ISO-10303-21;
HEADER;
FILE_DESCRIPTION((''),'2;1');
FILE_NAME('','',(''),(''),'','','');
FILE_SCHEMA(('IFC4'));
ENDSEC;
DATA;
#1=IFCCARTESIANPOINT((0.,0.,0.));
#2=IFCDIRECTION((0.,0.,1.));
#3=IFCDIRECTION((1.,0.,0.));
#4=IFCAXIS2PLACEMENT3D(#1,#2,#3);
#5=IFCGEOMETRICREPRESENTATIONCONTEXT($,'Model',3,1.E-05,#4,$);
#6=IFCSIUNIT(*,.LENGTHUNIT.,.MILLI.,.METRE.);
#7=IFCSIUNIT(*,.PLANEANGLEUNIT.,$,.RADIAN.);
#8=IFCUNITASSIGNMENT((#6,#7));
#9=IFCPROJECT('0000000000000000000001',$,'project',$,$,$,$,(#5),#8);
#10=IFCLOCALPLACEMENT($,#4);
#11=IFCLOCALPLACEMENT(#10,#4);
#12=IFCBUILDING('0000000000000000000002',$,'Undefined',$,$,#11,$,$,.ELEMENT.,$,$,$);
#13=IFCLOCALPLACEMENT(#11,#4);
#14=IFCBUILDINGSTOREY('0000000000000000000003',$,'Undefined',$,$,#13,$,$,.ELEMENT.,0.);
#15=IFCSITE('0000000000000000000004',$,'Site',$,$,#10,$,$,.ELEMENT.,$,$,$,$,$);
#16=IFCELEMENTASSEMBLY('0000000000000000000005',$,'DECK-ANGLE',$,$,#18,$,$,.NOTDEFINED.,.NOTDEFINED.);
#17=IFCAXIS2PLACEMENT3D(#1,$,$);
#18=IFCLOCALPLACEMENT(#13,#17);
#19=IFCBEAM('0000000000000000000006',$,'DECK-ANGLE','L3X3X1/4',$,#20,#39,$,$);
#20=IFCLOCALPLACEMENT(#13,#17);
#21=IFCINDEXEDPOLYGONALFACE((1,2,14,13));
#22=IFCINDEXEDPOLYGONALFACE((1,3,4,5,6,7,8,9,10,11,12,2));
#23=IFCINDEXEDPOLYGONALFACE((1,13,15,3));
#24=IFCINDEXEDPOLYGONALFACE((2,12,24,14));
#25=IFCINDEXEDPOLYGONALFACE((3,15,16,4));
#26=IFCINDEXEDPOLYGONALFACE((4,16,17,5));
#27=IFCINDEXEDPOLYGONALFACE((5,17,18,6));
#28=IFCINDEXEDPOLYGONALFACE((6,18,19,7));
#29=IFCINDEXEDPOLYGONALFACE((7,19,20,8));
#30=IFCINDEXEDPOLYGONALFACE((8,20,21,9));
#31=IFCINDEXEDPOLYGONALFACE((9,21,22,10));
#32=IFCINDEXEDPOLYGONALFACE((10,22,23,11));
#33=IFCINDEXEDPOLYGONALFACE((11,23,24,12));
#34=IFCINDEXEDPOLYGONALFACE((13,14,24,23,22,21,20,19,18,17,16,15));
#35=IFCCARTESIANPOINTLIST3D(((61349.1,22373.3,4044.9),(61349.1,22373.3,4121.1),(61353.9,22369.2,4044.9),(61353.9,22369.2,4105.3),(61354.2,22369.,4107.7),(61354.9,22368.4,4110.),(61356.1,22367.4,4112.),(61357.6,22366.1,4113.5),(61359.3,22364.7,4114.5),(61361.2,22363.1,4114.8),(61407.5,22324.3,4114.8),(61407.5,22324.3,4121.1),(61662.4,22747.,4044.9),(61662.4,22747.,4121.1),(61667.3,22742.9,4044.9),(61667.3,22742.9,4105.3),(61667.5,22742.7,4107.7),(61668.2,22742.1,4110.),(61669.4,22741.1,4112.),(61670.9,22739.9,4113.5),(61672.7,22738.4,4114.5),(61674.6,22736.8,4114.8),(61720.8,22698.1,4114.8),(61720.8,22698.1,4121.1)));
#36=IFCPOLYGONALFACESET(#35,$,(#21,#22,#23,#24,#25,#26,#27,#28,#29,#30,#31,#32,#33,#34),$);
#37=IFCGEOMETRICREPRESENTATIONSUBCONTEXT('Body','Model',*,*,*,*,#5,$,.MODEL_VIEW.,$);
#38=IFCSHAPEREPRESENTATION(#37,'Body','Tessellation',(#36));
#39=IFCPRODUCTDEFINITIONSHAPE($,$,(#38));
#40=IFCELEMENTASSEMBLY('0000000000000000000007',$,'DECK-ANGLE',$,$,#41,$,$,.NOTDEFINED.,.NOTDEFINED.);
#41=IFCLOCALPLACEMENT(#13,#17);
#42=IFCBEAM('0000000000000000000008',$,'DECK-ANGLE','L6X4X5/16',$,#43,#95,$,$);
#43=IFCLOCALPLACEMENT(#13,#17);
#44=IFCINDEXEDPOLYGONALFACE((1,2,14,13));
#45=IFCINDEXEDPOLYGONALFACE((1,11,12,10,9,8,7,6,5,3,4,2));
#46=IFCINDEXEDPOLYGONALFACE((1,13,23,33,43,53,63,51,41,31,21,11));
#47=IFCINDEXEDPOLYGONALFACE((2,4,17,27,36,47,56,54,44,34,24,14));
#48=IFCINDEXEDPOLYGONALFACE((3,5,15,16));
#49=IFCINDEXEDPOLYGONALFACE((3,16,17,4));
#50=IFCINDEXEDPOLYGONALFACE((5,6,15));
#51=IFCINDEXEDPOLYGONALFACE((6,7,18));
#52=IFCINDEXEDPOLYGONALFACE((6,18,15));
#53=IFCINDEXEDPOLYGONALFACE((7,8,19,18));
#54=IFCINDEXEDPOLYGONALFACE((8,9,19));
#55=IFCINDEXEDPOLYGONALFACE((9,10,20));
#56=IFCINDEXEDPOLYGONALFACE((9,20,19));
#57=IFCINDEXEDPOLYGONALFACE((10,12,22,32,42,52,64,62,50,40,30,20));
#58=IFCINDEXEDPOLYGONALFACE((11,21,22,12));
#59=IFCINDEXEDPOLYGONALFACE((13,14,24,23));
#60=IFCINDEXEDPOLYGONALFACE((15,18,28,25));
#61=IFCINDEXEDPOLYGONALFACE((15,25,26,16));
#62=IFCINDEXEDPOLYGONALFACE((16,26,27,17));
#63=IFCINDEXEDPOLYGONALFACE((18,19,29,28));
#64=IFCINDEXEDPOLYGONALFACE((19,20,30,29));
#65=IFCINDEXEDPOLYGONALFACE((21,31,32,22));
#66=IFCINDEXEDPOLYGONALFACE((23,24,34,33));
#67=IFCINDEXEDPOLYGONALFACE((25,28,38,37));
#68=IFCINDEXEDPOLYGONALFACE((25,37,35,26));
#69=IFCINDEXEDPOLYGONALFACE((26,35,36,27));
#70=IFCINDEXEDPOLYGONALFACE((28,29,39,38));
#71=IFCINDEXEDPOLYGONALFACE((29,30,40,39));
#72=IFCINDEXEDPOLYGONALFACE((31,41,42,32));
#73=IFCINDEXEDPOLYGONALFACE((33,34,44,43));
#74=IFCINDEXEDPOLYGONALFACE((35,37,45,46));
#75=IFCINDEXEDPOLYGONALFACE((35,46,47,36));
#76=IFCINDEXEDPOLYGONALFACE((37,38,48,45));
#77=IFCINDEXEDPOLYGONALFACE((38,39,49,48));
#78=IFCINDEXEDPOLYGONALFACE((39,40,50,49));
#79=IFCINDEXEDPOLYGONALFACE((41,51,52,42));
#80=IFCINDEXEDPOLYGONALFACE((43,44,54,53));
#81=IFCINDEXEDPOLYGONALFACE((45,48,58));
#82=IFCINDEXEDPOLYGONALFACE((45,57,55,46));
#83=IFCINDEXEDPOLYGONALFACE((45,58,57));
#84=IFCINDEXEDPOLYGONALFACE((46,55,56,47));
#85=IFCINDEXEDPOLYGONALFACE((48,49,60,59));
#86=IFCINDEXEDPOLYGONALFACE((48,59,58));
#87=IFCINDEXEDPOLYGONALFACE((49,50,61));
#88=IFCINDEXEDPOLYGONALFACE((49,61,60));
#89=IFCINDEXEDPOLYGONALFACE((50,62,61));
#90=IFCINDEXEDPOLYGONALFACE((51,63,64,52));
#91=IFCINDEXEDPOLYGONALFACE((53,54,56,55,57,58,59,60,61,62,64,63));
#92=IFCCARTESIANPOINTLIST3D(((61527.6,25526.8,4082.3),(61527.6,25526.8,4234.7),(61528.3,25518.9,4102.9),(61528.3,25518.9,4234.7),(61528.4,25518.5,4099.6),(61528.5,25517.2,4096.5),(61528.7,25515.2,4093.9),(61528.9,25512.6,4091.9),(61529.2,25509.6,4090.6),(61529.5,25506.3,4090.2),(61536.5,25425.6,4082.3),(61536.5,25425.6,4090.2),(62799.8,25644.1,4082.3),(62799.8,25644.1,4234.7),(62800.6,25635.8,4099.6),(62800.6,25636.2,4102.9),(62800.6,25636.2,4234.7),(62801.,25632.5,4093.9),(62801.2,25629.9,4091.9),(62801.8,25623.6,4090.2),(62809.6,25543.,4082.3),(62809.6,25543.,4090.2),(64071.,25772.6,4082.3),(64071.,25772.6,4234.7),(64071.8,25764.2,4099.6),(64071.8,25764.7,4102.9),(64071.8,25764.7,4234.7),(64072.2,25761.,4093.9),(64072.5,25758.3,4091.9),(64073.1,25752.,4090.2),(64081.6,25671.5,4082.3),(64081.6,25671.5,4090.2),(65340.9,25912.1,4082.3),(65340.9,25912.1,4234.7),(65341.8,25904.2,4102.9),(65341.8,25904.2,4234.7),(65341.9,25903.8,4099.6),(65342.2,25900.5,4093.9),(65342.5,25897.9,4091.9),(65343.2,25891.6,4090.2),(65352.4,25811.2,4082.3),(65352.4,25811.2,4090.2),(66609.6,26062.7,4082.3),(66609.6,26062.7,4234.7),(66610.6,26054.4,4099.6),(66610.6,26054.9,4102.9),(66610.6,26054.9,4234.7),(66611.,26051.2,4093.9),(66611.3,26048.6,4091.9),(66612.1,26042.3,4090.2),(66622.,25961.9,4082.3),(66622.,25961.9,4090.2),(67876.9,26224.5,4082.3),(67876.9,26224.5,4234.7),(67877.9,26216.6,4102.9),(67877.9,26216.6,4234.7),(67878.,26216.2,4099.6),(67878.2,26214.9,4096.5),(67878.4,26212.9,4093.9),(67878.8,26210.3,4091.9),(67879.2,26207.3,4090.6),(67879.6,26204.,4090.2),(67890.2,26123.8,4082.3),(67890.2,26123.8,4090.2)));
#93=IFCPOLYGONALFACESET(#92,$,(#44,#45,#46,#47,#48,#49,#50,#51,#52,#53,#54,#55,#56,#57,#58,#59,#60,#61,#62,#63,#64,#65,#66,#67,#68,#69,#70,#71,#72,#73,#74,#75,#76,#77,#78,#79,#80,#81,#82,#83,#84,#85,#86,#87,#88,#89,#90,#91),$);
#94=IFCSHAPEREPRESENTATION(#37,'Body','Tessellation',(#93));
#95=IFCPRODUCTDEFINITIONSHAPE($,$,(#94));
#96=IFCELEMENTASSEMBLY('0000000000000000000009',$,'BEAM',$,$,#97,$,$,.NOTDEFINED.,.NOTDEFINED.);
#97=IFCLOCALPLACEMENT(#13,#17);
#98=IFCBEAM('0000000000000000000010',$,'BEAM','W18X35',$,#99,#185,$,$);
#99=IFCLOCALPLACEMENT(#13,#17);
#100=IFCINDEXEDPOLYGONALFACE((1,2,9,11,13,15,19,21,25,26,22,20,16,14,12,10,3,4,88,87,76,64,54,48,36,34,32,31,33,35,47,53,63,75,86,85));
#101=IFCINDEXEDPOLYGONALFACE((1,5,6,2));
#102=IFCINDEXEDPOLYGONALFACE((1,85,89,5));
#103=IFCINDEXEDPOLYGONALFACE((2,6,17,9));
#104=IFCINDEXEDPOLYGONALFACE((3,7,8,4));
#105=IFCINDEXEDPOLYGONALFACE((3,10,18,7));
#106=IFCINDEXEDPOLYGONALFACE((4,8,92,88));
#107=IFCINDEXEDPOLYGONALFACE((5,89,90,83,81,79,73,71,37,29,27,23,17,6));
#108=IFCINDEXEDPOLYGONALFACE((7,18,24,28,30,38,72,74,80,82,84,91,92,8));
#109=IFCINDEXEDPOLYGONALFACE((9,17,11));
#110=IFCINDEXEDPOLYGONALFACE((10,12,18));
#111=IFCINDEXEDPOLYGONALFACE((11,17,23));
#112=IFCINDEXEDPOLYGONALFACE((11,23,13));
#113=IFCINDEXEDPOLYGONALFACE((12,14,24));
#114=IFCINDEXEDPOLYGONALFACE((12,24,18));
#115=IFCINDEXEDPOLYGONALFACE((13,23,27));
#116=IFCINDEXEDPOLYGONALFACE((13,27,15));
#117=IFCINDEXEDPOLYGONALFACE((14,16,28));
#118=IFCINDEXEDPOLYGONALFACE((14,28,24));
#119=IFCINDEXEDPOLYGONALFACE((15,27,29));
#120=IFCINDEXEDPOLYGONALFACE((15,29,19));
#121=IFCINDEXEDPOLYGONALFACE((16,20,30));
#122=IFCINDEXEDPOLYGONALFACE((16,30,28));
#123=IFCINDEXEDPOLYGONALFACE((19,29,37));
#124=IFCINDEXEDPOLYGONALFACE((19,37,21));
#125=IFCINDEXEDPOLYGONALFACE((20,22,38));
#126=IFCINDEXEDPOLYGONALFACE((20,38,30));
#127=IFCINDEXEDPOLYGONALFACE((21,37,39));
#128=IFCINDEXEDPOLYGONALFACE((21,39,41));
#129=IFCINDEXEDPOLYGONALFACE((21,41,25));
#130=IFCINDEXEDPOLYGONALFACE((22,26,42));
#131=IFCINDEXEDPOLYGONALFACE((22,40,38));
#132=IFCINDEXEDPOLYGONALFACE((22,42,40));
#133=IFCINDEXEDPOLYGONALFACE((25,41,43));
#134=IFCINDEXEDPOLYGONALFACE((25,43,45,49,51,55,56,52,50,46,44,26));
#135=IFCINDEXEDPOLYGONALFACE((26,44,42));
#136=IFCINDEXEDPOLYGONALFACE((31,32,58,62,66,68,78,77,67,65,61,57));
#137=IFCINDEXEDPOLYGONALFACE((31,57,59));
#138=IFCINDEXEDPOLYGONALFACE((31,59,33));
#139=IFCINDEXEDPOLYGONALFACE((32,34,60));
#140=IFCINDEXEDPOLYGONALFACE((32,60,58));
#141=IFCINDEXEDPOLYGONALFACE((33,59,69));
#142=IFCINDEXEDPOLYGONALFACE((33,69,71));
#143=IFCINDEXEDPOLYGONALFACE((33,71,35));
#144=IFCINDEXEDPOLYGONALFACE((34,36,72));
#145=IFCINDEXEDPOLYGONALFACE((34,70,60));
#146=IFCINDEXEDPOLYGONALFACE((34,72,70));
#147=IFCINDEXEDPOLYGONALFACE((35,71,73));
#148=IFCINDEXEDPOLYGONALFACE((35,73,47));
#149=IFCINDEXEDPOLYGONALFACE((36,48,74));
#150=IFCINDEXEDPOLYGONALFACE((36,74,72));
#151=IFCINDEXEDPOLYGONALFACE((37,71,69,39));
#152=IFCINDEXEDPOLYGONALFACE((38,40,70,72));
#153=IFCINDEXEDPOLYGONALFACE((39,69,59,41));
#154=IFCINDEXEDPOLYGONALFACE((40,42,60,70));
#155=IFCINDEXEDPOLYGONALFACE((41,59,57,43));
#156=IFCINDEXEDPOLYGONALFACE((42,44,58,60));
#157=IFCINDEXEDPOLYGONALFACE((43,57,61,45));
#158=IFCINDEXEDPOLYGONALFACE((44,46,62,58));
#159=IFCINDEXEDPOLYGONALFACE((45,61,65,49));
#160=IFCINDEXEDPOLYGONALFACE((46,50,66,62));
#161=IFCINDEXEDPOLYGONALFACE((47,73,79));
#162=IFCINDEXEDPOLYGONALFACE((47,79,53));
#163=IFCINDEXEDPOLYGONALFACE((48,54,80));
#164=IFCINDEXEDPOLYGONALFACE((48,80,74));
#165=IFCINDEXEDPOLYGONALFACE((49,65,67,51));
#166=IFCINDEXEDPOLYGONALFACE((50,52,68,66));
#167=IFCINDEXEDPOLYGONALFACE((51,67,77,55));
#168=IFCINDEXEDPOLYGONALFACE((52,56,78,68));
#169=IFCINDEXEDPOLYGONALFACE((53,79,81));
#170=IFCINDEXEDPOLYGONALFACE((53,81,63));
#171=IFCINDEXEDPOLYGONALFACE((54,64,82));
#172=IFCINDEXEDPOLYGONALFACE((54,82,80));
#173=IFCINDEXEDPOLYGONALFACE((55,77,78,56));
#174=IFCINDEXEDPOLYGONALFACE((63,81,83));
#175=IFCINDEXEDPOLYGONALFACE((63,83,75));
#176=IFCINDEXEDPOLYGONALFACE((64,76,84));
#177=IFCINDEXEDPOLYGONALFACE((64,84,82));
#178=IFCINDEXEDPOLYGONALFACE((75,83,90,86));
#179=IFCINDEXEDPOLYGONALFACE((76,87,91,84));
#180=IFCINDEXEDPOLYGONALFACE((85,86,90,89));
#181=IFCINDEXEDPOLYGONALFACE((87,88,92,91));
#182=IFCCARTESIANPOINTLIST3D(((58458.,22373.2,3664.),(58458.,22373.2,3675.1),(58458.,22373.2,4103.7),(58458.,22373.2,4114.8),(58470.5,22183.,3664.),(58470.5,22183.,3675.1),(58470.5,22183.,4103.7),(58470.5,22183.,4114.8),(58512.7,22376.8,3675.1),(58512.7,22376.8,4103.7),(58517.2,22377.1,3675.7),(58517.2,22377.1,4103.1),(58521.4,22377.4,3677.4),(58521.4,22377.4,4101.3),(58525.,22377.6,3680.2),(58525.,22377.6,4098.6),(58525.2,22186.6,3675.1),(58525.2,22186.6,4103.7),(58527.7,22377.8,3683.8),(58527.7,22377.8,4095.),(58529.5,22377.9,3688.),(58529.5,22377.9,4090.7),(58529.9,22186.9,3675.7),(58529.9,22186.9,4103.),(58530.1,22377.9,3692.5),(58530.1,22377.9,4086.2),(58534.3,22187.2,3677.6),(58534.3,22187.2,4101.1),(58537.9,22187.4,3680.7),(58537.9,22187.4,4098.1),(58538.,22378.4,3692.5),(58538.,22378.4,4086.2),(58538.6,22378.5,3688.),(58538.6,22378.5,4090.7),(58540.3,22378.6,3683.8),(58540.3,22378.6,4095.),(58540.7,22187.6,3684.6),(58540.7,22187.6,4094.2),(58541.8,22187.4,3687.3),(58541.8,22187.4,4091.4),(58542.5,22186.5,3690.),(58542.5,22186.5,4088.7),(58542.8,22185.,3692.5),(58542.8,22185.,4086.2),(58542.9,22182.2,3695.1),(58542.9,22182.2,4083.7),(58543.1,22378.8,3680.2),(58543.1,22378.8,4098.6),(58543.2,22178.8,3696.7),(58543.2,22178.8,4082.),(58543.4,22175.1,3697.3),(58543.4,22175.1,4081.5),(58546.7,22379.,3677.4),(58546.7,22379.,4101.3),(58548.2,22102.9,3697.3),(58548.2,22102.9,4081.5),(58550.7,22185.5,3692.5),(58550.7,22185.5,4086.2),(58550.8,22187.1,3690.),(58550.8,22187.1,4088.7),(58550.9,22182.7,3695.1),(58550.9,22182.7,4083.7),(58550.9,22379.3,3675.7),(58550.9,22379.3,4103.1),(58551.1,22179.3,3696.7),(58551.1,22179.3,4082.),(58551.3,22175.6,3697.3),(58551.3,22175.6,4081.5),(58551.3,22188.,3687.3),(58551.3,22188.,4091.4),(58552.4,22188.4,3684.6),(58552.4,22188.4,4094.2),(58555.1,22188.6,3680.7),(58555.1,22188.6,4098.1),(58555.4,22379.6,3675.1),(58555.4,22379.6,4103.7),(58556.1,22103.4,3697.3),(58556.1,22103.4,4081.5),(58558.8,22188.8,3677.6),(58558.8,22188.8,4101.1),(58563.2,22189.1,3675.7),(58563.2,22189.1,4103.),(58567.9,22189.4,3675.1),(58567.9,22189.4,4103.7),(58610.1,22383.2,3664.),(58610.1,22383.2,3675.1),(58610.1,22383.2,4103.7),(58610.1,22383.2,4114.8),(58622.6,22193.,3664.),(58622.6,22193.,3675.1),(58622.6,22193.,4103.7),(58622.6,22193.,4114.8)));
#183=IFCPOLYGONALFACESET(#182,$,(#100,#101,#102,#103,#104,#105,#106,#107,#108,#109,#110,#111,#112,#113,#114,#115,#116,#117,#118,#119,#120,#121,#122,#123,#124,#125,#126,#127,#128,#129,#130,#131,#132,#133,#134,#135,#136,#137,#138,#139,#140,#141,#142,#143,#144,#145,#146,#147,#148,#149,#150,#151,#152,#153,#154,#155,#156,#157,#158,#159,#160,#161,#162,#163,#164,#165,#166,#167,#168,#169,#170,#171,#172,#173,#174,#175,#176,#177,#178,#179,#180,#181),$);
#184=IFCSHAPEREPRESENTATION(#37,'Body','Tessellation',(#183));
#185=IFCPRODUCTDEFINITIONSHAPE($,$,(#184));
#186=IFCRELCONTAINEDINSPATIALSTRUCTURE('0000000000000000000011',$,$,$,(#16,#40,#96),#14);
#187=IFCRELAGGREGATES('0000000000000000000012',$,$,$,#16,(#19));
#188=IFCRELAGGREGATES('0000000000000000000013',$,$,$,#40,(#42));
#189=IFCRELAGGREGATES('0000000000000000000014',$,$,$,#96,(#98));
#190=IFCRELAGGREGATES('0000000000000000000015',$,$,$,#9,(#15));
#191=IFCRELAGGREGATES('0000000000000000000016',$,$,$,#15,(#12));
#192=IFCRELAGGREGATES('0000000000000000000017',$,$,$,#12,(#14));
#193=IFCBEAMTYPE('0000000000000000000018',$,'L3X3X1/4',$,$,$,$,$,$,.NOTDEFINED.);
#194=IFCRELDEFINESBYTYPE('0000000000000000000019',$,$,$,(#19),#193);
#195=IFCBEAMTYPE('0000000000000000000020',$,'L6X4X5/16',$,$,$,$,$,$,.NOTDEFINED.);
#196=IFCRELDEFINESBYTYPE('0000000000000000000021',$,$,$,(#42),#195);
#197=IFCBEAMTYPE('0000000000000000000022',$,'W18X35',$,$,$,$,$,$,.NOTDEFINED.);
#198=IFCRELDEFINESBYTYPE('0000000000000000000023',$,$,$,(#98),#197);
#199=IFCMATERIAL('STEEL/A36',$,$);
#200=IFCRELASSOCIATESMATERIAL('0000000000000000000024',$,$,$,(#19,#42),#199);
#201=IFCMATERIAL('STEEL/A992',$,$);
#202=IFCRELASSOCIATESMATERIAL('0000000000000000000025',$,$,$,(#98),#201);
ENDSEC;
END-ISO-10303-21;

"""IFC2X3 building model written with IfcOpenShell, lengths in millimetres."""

from ifc_helpers import new_model, entity, si_unit, frame, frame_2d, origin_with_axes, origin_2d_with_axis, place, context, subcontext, project, spatial, polyline, circle_curve, parameter, trimmed, segment, composite_curve, i_section, l_section, outline, extrude, boolean, halfspace, material, type_object, element, aggregate, save


model = new_model("IFC2X3")

# Units and contexts
model_context = context("Model", 3, precision=1e-05, world=origin_with_axes())
body_context = subcontext(model_context, "Body", "Model", "MODEL_VIEW")
ifc_project = project(units=[si_unit("LENGTHUNIT", "METRE", prefix="MILLI"), si_unit("PLANEANGLEUNIT", "RADIAN")], contexts=[model_context])

# Site, building, storey
site_placement = place(None, origin_with_axes())
site = spatial("IfcSite", under=ifc_project, at=site_placement, Name="Site", CompositionType="ELEMENT")
building_placement = place(site_placement, origin_with_axes())
building = spatial("IfcBuilding", under=site, at=building_placement, Name="Undefined", CompositionType="ELEMENT")
storey_placement = place(building_placement, origin_with_axes())
storey = spatial("IfcBuildingStorey", under=building, at=storey_placement, Name="Undefined", CompositionType="ELEMENT", Elevation=0.0)

# Element assemblies, beams
ifc_material_1 = material(Name="STEEL/A36")
beam_type_1 = type_object("IfcBeamType", Name="L3X3X1/4", PredefinedType="NOTDEFINED")
assembly_1_placement = place(storey_placement, origin_with_axes())
assembly_1 = element("IfcElementAssembly", 1, at=assembly_1_placement, inside=storey, Name="DECK-ANGLE", AssemblyPlace="NOTDEFINED", PredefinedType="NOTDEFINED")
beam_1_placement = place(assembly_1_placement, frame((61691.6, 22722.5, 4083.0), z_axis=(0.0, 0.0, -1.0), x_axis=(-0.642441, -0.766335, 0.0)))
beam_1 = element("IfcBeam", 2, at=beam_1_placement, type_object=beam_type_1, material=ifc_material_1, Name="DECK-ANGLE", Description="L3X3X1/4", context=body_context, shape_type="SweptSolid", body=[
    extrude(l_section(Depth=76.2, Width=76.2, Thickness=6.3, FilletRadius=9.5, at=origin_2d_with_axis()), frame((487.7, 0.0, 0.0), z_axis=(-1.0, 0.0, 0.0), x_axis=(0.0, -1.0, 0.0)), (0.0, 0.0, 1.0), 487.7),
])
aggregate(assembly_1, [beam_1])
assembly_2_placement = place(storey_placement, origin_with_axes())
assembly_2 = element("IfcElementAssembly", 3, at=assembly_2_placement, inside=storey, Name="DECK-ANGLE", AssemblyPlace="NOTDEFINED", PredefinedType="NOTDEFINED")
beam_type_2 = type_object("IfcBeamType", Name="L6X4X5/16", PredefinedType="NOTDEFINED")
beam_2_placement = place(assembly_2_placement, frame((61532.1, 25476.2, 4158.5), z_axis=(0.0, 0.0, 1.0), x_axis=(0.994018, 0.109219, 0.0)))
beam_2 = element("IfcBeam", 4, at=beam_2_placement, type_object=beam_type_2, material=ifc_material_1, Name="DECK-ANGLE", Description="L6X4X5/16", context=body_context, shape_type="SweptSolid", body=[
    entity("IfcRevolvedAreaSolid", entity("IfcLShapeProfileDef", "AREA", None, entity("IfcAxis2Placement2D", entity("IfcCartesianPoint", [0.0, 0.0]), entity("IfcDirection", [1.0, 0.0])), 152.4, 101.6, 7.9, 12.7), entity("IfcAxis2Placement3D", entity("IfcCartesianPoint", [6389.7, 0.0, 0.0]), entity("IfcDirection", [-0.999761, -0.021875, 0.0]), entity("IfcDirection", [0.021875, -0.999761, 0.0])), entity("IfcAxis1Placement", entity("IfcCartesianPoint", [-146050.0, 0.0, 0.0]), entity("IfcDirection", [0.0, -1.0, 0.0])), 0.043753),
])
aggregate(assembly_2, [beam_2])
assembly_3_placement = place(storey_placement, origin_with_axes())
assembly_3 = element("IfcElementAssembly", 5, at=assembly_3_placement, inside=storey, Name="BEAM", AssemblyPlace="NOTDEFINED", PredefinedType="NOTDEFINED")
ifc_material_2 = material(Name="STEEL/A992")
beam_type_3 = type_object("IfcBeamType", Name="W18X35", PredefinedType="NOTDEFINED")
beam_3_placement = place(assembly_3_placement, frame((58552.4, 22099.4, 3889.4), z_axis=(0.0, 0.0, 1.0), x_axis=(-0.065571, 0.997848, 0.0)))
beam_3 = element("IfcBeam", 6, at=beam_3_placement, type_object=beam_type_3, material=ifc_material_2, Name="BEAM", Description="W18X35", context=body_context, shape_type="CSG", body=[
    boolean("DIFFERENCE", boolean("DIFFERENCE", boolean("DIFFERENCE", boolean("DIFFERENCE", extrude(i_section(OverallWidth=152.4, OverallDepth=450.9, WebThickness=7.9, FlangeThickness=11.1, FilletRadius=17.5, at=origin_2d_with_axis()), frame((298.4, 0.0, 0.0), z_axis=(-1.0, 0.0, 0.0), x_axis=(0.0, -1.0, 0.0)), (0.0, 0.0, 1.0), 309.7), extrude(outline(composite_curve([segment(polyline([(0.0, 0.0), (82.3, 0.0)]), True, "CONTINUOUS"), segment(trimmed(circle_curve(frame_2d((82.3, 12.7), x_axis=(0.0, -1.0)), 12.7), [parameter(0.0)], [parameter(1.570796)], True, "PARAMETER"), True, "CONTINUOUS"), segment(polyline([(95.0, 12.7), (95.0, 43.3), (0.0, 43.3), (0.0, 0.0)]), True, "CONTINUOUS")], self_intersect=True)), frame((-6.2, -86.2, -192.1), z_axis=(-0.000015, 1.0, 0.0), x_axis=(1.0, 0.000015, 0.0)), (0.0, 0.0, 1.0), 172.4)), extrude(outline(composite_curve([segment(polyline([(0.0, 0.0), (82.3, 0.0)]), True, "CONTINUOUS"), segment(trimmed(circle_curve(frame_2d((82.3, 12.7), x_axis=(0.0, -1.0)), 12.7), [parameter(0.0)], [parameter(1.570796)], True, "PARAMETER"), True, "CONTINUOUS"), segment(polyline([(95.0, 12.7), (95.0, 43.3), (0.0, 43.3), (0.0, 0.0)]), True, "CONTINUOUS")], self_intersect=True)), frame((-6.2, 86.2, 192.1), z_axis=(0.000015, -1.0, 0.0), x_axis=(1.0, 0.000015, 0.0)), (0.0, 0.0, 1.0), 172.4)), halfspace(frame((279.4, 101.6, -1025.4), z_axis=(-1.0, 0.0, 0.0), x_axis=(0.0, 0.0, 1.0)), True)), halfspace(frame((3.8, 0.0, 325.4), z_axis=(-1.0, -0.00004, 0.0), x_axis=(0.00004, -1.0, 0.0)), False)),
])

aggregate(assembly_3, [beam_3])

save(model, "model.ifc")
